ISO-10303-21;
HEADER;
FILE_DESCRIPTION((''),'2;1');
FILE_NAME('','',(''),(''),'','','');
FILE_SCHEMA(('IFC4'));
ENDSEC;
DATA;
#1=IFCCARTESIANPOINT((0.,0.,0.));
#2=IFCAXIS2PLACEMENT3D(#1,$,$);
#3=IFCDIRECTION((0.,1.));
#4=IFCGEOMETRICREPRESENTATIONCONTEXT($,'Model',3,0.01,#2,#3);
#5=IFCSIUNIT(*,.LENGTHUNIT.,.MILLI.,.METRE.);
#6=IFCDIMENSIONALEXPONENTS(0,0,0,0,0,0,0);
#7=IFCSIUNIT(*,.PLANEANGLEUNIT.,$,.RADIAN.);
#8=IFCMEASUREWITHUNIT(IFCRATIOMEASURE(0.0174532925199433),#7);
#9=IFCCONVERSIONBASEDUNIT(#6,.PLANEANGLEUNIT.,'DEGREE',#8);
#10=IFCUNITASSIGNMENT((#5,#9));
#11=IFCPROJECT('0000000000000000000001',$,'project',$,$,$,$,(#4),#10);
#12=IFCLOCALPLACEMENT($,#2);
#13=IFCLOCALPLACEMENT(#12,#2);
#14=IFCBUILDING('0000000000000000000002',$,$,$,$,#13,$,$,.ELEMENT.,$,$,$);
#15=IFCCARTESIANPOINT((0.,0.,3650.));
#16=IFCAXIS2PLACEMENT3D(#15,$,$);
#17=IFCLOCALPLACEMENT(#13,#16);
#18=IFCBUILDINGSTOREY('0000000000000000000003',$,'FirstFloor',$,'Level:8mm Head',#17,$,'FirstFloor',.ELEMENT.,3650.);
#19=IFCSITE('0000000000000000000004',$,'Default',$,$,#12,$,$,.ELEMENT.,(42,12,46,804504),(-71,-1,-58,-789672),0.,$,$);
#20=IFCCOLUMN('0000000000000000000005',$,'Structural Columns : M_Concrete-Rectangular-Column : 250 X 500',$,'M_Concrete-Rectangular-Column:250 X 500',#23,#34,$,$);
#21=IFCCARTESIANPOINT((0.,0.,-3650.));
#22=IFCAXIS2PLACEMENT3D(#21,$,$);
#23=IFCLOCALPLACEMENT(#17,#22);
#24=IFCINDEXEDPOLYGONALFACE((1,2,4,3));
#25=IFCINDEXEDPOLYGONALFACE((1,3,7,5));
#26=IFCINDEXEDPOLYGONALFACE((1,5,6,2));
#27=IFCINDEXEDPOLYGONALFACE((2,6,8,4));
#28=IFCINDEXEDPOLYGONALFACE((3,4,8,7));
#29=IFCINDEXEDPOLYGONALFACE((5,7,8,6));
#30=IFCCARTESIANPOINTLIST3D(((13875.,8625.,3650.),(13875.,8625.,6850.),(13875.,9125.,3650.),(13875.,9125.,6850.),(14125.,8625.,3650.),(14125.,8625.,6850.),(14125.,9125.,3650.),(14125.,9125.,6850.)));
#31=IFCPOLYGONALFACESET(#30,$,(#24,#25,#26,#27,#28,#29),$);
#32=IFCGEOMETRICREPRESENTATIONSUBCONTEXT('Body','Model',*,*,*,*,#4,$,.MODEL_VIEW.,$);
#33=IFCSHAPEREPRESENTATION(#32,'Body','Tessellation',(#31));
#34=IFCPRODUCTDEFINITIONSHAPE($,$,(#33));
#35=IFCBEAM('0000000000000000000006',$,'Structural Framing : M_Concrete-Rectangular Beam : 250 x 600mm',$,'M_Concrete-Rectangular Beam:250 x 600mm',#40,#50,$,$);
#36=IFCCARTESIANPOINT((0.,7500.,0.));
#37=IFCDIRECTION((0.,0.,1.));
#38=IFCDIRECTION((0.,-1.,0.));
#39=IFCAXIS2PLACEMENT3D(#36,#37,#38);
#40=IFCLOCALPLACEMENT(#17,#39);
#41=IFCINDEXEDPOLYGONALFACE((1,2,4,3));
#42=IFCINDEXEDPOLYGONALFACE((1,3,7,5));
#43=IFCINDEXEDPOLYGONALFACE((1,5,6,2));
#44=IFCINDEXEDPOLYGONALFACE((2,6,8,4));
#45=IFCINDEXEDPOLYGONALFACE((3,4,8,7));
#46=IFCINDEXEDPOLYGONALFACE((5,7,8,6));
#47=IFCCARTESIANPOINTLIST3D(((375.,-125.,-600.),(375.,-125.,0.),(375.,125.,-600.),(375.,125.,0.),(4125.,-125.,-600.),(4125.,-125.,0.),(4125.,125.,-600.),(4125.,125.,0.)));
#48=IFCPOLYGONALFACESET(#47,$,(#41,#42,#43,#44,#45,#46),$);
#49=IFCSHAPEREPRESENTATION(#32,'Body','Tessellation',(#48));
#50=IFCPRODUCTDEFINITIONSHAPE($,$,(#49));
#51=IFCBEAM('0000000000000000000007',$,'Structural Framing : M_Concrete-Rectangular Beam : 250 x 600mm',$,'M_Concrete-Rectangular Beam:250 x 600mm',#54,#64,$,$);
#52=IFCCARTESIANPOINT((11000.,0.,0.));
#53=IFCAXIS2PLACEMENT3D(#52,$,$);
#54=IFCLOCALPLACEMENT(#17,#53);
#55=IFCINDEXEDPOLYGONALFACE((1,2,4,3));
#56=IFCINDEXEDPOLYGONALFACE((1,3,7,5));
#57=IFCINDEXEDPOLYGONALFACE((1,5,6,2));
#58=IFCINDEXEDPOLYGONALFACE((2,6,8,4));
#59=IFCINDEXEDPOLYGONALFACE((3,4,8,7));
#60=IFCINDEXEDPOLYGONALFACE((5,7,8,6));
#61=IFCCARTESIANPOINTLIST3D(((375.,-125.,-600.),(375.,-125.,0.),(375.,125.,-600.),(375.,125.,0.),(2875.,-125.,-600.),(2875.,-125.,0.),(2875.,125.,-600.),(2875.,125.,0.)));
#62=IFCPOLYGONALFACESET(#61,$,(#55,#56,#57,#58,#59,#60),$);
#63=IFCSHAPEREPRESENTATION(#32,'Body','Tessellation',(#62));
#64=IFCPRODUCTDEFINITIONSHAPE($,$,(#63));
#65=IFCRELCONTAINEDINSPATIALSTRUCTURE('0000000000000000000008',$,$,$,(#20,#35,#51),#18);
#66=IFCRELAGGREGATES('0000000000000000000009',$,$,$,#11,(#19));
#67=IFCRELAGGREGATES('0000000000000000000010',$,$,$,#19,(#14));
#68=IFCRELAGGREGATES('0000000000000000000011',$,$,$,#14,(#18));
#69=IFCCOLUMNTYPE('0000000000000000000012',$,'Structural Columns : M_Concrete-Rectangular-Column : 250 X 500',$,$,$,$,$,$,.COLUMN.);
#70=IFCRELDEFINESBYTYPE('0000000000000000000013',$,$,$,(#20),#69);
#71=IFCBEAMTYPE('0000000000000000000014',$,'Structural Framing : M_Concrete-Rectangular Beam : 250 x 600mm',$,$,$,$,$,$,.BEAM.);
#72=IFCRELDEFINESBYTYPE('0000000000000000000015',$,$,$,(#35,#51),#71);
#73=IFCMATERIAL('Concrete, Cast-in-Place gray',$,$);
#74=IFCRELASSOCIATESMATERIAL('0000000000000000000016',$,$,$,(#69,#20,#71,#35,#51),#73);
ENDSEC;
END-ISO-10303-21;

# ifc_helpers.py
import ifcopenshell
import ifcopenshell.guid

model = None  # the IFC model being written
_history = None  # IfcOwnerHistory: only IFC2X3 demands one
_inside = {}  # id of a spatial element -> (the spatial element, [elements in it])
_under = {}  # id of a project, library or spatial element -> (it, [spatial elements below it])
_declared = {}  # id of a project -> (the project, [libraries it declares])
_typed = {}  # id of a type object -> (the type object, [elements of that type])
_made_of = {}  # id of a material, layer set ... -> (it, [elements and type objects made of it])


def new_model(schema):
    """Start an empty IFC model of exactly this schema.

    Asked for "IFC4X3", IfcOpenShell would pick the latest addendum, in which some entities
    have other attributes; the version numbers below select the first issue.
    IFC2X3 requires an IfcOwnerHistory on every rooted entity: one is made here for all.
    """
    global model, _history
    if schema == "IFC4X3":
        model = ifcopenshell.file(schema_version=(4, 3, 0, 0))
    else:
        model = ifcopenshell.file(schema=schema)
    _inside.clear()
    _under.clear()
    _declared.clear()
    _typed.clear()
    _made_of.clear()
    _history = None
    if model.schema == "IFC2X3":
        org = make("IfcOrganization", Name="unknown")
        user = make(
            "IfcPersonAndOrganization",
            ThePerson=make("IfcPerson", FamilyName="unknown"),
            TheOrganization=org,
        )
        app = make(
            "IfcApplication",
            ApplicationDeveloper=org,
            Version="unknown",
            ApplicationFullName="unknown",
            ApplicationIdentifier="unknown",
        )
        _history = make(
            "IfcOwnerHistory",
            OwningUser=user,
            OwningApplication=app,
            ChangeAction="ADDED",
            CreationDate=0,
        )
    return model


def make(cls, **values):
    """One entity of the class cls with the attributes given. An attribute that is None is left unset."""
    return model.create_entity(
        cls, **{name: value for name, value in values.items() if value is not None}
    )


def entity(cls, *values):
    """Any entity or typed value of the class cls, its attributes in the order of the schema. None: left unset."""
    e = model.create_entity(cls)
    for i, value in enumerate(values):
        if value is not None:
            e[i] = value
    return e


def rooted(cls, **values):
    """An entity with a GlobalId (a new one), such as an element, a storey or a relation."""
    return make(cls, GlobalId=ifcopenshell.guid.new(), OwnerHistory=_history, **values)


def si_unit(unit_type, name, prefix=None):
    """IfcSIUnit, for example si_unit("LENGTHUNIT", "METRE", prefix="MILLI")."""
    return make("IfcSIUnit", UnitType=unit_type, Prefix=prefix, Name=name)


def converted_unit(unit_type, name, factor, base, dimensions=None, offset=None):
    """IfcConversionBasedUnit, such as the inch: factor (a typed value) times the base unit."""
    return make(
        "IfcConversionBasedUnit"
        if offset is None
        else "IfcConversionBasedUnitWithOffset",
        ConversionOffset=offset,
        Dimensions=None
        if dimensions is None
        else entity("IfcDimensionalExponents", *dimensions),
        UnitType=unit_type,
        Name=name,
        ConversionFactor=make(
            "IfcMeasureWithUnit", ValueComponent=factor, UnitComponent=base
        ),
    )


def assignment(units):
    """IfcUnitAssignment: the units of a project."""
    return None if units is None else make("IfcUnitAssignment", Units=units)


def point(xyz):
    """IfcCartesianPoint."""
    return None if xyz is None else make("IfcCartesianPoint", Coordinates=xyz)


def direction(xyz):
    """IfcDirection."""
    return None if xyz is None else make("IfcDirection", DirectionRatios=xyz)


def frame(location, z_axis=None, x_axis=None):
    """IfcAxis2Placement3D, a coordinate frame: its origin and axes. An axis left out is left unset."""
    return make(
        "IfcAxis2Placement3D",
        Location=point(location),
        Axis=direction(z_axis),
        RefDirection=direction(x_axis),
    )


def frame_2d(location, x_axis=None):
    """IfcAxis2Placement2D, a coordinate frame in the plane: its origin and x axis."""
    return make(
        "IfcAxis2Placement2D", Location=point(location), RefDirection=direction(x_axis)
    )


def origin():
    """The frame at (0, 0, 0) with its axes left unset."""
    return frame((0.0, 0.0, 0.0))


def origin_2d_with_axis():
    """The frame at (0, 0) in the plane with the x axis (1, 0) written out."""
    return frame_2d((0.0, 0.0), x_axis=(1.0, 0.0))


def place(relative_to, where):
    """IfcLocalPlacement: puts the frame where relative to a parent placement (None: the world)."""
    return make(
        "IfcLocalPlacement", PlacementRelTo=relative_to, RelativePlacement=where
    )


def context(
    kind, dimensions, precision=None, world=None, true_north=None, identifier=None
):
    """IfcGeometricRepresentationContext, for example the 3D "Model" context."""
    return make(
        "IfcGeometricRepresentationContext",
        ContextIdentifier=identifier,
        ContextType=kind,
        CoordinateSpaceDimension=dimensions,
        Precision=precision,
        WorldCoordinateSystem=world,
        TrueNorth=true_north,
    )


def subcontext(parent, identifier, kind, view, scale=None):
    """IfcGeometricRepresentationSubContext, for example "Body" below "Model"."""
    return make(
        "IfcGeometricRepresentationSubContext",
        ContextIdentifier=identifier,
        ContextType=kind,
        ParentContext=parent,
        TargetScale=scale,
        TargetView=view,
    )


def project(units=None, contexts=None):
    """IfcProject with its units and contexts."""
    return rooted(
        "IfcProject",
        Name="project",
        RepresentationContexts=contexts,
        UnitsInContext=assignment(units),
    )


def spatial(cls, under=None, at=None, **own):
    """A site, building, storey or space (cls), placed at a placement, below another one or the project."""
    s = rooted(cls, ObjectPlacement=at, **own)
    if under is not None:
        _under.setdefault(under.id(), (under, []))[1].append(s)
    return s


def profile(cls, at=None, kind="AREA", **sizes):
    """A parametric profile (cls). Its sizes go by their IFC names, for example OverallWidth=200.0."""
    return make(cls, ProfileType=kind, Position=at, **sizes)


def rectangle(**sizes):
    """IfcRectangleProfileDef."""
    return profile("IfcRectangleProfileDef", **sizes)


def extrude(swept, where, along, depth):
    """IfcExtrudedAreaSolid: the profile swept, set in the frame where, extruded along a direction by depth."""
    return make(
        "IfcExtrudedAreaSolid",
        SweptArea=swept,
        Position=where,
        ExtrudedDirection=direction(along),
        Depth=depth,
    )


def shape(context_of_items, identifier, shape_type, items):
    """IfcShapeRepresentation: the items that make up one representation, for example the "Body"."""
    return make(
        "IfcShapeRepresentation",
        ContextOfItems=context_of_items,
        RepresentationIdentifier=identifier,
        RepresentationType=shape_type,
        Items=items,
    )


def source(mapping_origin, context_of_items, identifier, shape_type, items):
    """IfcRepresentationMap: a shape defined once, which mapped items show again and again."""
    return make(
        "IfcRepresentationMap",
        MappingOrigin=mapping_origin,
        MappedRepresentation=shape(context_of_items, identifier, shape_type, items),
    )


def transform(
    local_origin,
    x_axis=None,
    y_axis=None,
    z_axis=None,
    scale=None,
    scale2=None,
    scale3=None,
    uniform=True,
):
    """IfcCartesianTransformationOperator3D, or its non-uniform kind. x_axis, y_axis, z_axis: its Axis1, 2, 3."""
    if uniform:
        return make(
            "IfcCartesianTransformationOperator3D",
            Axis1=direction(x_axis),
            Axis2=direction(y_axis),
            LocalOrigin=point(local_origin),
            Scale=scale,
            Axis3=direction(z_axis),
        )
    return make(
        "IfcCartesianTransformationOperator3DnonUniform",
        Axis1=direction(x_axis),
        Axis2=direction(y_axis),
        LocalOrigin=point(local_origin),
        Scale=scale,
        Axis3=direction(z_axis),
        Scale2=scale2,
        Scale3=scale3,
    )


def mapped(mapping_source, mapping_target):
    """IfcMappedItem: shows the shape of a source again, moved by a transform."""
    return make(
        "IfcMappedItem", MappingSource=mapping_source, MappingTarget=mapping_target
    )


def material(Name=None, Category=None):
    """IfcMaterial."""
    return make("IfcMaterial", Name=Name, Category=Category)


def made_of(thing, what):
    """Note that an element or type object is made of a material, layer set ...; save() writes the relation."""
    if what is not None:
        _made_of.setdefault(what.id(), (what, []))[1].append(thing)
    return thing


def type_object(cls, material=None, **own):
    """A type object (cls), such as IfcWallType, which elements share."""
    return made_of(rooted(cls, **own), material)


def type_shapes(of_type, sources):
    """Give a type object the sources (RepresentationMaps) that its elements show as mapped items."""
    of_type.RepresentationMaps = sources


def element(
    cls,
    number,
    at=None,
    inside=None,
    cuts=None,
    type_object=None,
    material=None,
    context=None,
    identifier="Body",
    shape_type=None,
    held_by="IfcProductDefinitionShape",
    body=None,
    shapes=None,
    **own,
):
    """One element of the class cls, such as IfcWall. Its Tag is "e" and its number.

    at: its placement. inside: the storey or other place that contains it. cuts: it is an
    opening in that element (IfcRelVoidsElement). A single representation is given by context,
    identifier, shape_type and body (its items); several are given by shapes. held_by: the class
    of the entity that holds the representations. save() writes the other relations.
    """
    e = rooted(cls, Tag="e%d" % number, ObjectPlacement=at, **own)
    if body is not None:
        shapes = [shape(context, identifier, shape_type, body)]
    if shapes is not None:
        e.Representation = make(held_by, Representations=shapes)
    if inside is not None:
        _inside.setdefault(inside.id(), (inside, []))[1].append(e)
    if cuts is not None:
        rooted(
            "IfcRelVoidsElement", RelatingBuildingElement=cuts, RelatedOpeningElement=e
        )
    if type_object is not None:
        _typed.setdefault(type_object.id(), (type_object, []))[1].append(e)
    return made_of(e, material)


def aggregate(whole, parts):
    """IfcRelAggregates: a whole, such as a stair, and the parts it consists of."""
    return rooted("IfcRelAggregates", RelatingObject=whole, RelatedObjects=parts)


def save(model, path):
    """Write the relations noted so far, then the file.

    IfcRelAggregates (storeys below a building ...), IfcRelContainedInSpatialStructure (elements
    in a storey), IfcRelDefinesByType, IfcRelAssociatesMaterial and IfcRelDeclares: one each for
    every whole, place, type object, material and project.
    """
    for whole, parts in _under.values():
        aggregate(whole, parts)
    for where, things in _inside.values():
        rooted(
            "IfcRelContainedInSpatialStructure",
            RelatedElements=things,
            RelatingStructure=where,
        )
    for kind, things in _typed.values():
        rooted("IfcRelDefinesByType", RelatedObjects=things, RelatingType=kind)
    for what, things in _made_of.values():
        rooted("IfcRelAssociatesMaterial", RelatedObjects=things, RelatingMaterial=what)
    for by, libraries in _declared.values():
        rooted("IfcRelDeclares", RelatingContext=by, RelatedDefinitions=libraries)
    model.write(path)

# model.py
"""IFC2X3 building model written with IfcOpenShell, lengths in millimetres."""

from ifc_helpers import new_model, entity, si_unit, converted_unit, direction, frame, frame_2d, origin, origin_2d_with_axis, place, context, subcontext, project, spatial, rectangle, extrude, source, transform, mapped, material, type_object, type_shapes, element, save


model = new_model("IFC2X3")

# Units and contexts
model_context = context("Model", 3, precision=0.01, world=origin(), true_north=direction((0.0, 1.0)))
body_context = subcontext(model_context, "Body", "Model", "MODEL_VIEW")
ifc_project = project(units=[si_unit("LENGTHUNIT", "METRE", prefix="MILLI"), converted_unit("PLANEANGLEUNIT", "DEGREE", entity("IfcRatioMeasure", 0.0174532925199433), si_unit("PLANEANGLEUNIT", "RADIAN"), dimensions=[0, 0, 0, 0, 0, 0, 0])], contexts=[model_context])

# Site, building, storey
site_placement = place(None, origin())
site = spatial("IfcSite", under=ifc_project, at=site_placement, Name="Default", CompositionType="ELEMENT", RefLatitude=(42, 12, 46, 804504), RefLongitude=(-71, -1, -58, -789672), RefElevation=0.0)
building_placement = place(site_placement, origin())
building = spatial("IfcBuilding", under=site, at=building_placement, CompositionType="ELEMENT")
storey_placement = place(building_placement, frame((0.0, 0.0, 3650.0)))
storey = spatial("IfcBuildingStorey", under=building, at=storey_placement, Name="FirstFloor", ObjectType="Level:8mm Head", LongName="FirstFloor", CompositionType="ELEMENT", Elevation=3650.0)

# Column
ifc_material = material(Name="Concrete, Cast-in-Place gray")
column_type_1 = type_object("IfcColumnType", Name="Structural Columns : M_Concrete-Rectangular-Column : 250 X 500", PredefinedType="COLUMN", material=ifc_material)
shared_shape_1 = source(origin(), body_context, "Body", "SweptSolid", [
    extrude(rectangle(XDim=500.0, YDim=250.0, at=frame_2d((0.0, 0.0), x_axis=(1.0, 0.0))), frame((14000.0, 8875.0, 3650.0), z_axis=(0.0, 0.0, 1.0), x_axis=(0.0, -1.0, 0.0)), (0.0, 0.0, 1.0), 3200.0),
])
type_shapes(column_type_1, [shared_shape_1])
column_1_placement = place(storey_placement, frame((0.0, 0.0, -3650.0)))
element("IfcColumn", 1, at=column_1_placement, inside=storey, type_object=column_type_1, material=ifc_material, Name="Structural Columns : M_Concrete-Rectangular-Column : 250 X 500", ObjectType="M_Concrete-Rectangular-Column:250 X 500", context=body_context, shape_type="MappedRepresentation", body=[
    mapped(shared_shape_1, transform((0.0, 0.0, 0.0), scale=1.0)),
])

# Beams
beam_type_1 = type_object("IfcBeamType", Name="Structural Framing : M_Concrete-Rectangular Beam : 250 x 600mm", PredefinedType="BEAM", material=ifc_material)
beam_1_placement = place(storey_placement, frame((0.0, 7500.0, 0.0), z_axis=(0.0, 0.0, 1.0), x_axis=(0.0, -1.0, 0.0)))
element("IfcBeam", 2, at=beam_1_placement, inside=storey, type_object=beam_type_1, material=ifc_material, Name="Structural Framing : M_Concrete-Rectangular Beam : 250 x 600mm", ObjectType="M_Concrete-Rectangular Beam:250 x 600mm", context=body_context, shape_type="SweptSolid", body=[
    extrude(rectangle(XDim=600.0, YDim=250.0, at=origin_2d_with_axis()), frame((375.0, 0.0, -300.0), z_axis=(1.0, 0.0, 0.0), x_axis=(0.0, 0.0, -1.0)), (0.0, 0.0, 1.0), 3750.0),
])
beam_2_placement = place(storey_placement, frame((11000.0, 0.0, 0.0)))
element("IfcBeam", 3, at=beam_2_placement, inside=storey, type_object=beam_type_1, material=ifc_material, Name="Structural Framing : M_Concrete-Rectangular Beam : 250 x 600mm", ObjectType="M_Concrete-Rectangular Beam:250 x 600mm", context=body_context, shape_type="SweptSolid", body=[
    extrude(rectangle(XDim=600.0, YDim=250.0, at=frame_2d((0.0, 0.0), x_axis=(1.0, 0.0))), frame((375.0, 0.0, -300.0), z_axis=(1.0, 0.0, 0.0), x_axis=(0.0, 0.0, -1.0)), (0.0, 0.0, 1.0), 2500.0),
])

save(model, "model.ifc")
